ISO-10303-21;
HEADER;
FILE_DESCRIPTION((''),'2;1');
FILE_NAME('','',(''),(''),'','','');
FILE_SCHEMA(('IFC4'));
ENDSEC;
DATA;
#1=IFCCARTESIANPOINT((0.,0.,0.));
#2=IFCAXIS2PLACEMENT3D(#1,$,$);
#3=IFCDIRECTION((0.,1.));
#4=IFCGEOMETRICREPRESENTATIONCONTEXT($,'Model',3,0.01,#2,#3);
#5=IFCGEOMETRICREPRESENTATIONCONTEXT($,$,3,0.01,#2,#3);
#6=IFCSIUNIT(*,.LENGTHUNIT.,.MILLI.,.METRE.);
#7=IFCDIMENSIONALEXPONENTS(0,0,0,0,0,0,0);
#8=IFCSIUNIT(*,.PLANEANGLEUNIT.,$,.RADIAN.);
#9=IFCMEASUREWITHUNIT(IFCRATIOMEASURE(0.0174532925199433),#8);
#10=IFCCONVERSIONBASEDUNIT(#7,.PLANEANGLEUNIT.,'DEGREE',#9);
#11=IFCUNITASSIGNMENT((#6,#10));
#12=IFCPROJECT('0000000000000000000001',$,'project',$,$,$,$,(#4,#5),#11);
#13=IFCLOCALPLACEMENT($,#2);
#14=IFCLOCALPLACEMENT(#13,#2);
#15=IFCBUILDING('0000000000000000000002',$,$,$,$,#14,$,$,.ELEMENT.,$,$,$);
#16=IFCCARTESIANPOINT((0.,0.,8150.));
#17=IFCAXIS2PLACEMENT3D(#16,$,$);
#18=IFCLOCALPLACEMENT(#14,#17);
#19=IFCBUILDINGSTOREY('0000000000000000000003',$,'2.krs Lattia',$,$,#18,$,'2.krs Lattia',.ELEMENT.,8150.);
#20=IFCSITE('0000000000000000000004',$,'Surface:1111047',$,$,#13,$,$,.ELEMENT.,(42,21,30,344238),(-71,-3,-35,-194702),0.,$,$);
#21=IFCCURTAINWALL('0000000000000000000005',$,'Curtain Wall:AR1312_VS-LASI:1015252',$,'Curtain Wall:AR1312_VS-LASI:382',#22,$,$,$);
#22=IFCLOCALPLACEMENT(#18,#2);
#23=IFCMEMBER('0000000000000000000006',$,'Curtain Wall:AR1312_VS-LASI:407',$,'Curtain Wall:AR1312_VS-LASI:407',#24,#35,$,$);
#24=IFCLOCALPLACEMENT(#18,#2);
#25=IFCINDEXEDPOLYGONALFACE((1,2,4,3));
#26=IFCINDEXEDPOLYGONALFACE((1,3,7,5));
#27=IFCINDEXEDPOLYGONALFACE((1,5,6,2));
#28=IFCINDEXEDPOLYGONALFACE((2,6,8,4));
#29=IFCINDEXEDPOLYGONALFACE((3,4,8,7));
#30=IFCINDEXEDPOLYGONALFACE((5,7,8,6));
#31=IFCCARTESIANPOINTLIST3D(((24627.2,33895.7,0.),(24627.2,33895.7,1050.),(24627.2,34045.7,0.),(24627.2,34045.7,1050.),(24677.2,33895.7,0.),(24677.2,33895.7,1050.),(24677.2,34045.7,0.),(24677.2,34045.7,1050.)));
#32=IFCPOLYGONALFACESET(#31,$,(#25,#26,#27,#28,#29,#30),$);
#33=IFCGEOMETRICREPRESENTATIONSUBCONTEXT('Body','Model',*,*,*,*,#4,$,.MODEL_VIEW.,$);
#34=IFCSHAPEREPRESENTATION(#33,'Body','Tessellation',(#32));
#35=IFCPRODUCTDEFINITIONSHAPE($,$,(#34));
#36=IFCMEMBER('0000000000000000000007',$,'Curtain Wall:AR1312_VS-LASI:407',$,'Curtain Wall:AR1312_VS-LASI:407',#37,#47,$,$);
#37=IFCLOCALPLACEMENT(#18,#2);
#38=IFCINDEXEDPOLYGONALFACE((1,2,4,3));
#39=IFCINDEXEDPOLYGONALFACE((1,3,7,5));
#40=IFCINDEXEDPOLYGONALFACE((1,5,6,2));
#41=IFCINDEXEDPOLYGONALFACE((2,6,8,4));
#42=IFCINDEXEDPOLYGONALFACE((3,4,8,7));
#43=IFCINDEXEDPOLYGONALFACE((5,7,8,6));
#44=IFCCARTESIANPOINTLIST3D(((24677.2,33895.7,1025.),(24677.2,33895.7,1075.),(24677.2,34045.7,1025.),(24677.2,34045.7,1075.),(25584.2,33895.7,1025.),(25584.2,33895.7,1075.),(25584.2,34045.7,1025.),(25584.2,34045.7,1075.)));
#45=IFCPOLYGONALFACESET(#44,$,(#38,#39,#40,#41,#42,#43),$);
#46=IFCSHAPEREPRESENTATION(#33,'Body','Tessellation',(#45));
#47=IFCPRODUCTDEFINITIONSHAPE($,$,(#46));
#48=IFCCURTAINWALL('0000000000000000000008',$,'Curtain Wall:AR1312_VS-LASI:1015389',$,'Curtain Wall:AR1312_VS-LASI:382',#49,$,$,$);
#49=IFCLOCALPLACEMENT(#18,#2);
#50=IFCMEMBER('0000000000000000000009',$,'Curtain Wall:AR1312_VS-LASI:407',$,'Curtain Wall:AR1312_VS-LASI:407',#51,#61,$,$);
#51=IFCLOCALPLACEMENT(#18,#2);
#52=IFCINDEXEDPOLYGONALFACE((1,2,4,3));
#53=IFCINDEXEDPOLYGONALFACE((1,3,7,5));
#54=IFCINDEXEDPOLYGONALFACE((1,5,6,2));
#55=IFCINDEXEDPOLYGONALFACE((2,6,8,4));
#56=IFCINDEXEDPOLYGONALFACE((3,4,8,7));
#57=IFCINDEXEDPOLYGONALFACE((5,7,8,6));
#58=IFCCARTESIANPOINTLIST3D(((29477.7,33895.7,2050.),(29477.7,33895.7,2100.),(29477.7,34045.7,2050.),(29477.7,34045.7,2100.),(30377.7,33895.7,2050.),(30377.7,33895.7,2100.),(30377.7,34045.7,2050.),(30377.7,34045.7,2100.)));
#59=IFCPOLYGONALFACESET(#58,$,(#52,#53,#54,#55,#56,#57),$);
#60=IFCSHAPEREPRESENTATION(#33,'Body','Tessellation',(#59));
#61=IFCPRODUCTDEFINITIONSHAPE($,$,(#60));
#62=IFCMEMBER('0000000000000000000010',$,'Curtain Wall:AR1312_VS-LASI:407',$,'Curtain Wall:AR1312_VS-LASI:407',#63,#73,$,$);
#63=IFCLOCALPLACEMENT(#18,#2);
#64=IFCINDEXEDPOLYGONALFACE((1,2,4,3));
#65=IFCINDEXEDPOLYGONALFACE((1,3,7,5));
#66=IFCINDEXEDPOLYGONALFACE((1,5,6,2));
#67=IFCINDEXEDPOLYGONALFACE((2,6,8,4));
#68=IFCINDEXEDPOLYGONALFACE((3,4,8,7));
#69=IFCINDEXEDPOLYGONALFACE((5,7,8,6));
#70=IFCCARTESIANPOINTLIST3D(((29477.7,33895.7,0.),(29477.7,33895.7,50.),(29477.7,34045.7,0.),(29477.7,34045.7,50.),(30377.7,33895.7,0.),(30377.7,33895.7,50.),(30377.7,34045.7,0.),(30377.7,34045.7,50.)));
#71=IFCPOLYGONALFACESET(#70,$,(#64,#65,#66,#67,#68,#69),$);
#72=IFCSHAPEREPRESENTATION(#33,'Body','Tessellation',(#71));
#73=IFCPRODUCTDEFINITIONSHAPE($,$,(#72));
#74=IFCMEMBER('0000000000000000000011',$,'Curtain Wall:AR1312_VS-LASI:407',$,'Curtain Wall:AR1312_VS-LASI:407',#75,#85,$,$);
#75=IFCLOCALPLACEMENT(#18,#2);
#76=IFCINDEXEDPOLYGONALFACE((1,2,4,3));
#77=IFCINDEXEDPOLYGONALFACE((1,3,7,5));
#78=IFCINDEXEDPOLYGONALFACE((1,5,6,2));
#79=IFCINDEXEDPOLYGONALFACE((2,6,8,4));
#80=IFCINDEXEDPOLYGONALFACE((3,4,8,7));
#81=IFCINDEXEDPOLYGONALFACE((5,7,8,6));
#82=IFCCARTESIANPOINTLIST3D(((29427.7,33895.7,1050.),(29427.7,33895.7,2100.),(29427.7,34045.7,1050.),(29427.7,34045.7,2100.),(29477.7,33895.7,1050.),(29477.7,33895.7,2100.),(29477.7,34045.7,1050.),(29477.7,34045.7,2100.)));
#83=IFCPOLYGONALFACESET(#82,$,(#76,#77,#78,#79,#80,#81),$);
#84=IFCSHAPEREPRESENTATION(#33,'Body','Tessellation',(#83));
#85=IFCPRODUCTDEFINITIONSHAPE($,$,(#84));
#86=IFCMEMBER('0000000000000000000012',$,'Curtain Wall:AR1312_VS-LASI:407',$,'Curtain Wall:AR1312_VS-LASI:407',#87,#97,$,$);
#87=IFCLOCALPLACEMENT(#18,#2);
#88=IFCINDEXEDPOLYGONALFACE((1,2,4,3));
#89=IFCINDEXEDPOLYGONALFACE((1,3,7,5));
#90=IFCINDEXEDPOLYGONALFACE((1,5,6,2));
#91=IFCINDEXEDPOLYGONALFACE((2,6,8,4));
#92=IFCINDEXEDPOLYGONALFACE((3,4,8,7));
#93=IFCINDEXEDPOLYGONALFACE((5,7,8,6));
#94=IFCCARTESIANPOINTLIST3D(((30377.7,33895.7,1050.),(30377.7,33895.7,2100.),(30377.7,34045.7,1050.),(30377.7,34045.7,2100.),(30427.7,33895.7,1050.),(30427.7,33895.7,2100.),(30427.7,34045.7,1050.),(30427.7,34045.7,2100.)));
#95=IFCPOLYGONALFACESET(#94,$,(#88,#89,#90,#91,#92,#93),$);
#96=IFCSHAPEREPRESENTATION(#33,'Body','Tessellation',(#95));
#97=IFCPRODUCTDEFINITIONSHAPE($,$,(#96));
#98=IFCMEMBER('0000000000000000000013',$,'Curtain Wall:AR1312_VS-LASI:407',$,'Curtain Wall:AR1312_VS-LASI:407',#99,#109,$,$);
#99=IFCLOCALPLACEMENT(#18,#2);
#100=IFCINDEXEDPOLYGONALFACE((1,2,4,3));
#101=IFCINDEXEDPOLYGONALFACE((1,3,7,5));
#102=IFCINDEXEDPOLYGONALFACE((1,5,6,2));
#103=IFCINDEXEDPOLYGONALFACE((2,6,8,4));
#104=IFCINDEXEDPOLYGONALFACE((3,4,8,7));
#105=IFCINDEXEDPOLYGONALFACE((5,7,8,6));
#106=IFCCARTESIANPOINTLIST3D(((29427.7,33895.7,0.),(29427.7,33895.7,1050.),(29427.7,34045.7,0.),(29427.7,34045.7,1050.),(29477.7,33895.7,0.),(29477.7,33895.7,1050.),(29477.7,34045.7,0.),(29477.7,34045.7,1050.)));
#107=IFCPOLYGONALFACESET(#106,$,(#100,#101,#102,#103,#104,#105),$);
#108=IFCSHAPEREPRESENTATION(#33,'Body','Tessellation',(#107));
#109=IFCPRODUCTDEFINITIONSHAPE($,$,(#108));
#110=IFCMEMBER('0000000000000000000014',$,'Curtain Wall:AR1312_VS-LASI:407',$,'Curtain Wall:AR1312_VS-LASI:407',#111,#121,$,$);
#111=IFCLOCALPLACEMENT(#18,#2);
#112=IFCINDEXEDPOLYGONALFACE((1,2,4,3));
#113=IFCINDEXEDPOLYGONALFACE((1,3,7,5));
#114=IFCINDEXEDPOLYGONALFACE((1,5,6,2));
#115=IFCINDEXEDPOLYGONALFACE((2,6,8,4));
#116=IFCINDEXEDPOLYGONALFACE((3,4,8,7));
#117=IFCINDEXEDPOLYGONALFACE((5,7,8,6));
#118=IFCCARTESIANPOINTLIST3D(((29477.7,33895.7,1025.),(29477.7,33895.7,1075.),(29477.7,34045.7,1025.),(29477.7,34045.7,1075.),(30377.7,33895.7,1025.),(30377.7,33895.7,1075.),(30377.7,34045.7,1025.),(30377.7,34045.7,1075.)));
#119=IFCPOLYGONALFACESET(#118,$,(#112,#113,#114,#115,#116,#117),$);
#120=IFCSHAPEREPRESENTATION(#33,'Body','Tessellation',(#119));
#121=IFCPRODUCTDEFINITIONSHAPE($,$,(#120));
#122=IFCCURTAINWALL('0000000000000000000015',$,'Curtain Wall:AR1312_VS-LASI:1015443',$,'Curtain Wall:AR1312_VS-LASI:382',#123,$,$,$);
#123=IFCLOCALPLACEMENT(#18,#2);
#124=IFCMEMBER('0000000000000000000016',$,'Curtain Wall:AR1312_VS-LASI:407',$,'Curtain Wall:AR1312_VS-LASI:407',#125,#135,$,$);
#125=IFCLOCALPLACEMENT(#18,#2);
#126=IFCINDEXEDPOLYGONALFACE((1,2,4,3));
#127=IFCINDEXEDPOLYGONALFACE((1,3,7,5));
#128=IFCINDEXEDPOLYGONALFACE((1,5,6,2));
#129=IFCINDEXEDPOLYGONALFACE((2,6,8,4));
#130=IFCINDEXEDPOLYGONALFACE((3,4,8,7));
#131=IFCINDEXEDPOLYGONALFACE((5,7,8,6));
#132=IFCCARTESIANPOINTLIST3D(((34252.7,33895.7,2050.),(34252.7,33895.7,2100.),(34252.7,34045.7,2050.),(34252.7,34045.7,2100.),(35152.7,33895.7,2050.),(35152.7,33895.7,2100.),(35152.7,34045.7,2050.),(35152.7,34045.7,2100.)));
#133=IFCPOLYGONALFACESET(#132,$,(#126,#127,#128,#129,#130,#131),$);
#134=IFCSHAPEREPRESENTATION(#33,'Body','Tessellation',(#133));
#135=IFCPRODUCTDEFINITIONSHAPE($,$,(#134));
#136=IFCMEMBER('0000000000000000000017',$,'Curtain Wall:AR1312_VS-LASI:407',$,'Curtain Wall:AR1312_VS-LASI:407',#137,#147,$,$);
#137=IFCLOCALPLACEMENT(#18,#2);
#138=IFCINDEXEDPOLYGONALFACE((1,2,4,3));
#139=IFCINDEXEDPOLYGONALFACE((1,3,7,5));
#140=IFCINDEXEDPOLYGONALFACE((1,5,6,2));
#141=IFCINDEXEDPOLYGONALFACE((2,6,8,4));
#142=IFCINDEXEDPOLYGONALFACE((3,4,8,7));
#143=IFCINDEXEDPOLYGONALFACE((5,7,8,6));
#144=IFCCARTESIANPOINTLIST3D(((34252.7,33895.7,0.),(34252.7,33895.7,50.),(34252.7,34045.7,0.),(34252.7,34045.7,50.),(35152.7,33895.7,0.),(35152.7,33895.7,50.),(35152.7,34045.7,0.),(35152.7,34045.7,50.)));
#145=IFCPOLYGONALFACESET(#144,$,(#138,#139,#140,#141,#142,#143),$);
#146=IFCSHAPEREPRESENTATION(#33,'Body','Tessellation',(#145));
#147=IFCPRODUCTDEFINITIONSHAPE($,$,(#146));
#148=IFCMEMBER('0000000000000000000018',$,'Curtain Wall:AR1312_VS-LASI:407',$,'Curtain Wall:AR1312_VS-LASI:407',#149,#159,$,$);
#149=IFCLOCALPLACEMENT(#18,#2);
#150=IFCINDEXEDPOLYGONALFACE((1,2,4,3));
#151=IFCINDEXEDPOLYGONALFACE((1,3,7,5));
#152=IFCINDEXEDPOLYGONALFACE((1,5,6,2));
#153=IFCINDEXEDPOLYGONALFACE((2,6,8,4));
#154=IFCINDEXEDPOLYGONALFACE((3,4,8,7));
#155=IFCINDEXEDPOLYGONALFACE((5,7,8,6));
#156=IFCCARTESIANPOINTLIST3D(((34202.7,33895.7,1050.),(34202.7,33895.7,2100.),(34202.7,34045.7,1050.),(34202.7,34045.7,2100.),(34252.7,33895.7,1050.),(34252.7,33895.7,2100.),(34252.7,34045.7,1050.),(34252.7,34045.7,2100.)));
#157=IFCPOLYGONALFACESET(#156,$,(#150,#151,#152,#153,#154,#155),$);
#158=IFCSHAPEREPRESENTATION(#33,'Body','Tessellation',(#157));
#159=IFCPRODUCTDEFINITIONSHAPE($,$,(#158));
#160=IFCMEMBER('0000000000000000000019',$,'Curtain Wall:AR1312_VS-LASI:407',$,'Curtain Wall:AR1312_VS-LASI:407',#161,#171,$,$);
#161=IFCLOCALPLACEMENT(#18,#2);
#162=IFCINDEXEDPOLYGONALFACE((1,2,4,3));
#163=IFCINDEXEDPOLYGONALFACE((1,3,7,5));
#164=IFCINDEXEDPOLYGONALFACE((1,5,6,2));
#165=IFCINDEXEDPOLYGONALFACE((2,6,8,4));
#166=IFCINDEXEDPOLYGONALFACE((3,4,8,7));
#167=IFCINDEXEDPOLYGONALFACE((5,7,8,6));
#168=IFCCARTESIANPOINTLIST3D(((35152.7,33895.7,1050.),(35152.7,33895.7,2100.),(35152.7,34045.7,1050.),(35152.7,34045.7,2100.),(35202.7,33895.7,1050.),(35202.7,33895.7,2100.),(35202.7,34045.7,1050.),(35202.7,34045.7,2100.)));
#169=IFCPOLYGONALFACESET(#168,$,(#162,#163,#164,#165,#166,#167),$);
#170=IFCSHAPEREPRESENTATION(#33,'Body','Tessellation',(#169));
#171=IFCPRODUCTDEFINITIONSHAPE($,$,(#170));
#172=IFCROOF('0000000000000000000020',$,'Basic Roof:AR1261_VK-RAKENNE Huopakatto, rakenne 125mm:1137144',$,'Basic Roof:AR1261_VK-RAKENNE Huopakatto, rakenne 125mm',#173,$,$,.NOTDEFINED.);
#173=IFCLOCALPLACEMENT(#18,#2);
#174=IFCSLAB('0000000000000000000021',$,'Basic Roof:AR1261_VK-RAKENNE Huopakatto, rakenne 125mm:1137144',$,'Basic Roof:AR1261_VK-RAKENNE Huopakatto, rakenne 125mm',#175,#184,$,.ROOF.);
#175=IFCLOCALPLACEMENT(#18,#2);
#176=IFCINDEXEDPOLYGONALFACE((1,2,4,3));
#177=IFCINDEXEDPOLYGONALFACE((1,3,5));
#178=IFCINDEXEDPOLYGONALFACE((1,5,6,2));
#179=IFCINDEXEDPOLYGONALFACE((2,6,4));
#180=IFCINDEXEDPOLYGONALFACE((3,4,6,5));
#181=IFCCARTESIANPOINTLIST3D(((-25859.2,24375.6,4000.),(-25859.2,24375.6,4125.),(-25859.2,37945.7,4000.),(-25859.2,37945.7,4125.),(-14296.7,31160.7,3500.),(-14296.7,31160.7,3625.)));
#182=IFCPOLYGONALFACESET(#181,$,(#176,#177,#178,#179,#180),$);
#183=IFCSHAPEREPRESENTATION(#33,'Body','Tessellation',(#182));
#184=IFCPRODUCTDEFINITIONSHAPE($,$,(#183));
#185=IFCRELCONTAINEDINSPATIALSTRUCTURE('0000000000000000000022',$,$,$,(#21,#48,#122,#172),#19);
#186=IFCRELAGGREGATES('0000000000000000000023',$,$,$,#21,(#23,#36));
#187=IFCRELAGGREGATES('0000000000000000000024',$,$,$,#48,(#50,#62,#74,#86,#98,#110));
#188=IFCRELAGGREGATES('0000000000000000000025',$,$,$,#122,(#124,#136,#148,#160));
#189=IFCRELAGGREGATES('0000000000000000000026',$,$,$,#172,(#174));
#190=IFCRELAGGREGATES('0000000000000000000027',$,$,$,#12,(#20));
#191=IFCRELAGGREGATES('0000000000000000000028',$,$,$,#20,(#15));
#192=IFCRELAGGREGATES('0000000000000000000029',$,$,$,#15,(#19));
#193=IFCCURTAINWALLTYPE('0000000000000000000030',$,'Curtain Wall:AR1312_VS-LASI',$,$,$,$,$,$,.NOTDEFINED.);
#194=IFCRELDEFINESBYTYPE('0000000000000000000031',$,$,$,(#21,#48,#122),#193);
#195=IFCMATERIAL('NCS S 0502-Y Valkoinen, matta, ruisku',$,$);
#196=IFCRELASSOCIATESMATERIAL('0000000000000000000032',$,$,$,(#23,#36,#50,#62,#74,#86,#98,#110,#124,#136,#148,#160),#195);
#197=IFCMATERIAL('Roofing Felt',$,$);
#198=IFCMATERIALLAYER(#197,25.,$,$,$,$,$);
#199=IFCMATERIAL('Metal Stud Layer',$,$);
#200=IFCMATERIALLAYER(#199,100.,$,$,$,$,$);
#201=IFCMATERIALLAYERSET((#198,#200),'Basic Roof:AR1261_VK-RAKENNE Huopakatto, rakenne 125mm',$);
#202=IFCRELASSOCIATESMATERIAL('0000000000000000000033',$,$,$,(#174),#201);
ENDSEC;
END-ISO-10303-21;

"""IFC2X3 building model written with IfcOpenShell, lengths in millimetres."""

from ifc_helpers import new_model, entity, si_unit, converted_unit, direction, frame, frame_2d, origin, place, context, subcontext, project, spatial, polyline, rectangle, outline, extrude, material, layer, layer_set, type_object, element, aggregate, save


model = new_model("IFC2X3")

# Units and contexts
model_context = context("Model", 3, precision=0.01, world=origin(), true_north=direction((0.0, 1.0)))
context_of_model = context(None, 3, precision=0.01, world=origin(), true_north=direction((0.0, 1.0)))
body_context = subcontext(model_context, "Body", "Model", "MODEL_VIEW")
ifc_project = project(units=[si_unit("LENGTHUNIT", "METRE", prefix="MILLI"), converted_unit("PLANEANGLEUNIT", "DEGREE", entity("IfcRatioMeasure", 0.0174532925199433), si_unit("PLANEANGLEUNIT", "RADIAN"), dimensions=[0, 0, 0, 0, 0, 0, 0])], contexts=[model_context, context_of_model])

# Site, building, storey
site_placement = place(None, origin())
site = spatial("IfcSite", under=ifc_project, at=site_placement, Name="Surface:1111047", CompositionType="ELEMENT", RefLatitude=(42, 21, 30, 344238), RefLongitude=(-71, -3, -35, -194702), RefElevation=0.0)
building_placement = place(site_placement, origin())
building = spatial("IfcBuilding", under=site, at=building_placement, CompositionType="ELEMENT")
storey_placement = place(building_placement, frame((0.0, 0.0, 8150.0)))
storey = spatial("IfcBuildingStorey", under=building, at=storey_placement, Name="2.krs Lattia", LongName="2.krs Lattia", CompositionType="ELEMENT", Elevation=8150.0)

# Curtain walls, members
curtain_wall_type = type_object("IfcCurtainWallType", Name="Curtain Wall:AR1312_VS-LASI", PredefinedType="NOTDEFINED")
curtain_wall_1_placement = place(storey_placement, frame((0.0, 0.0, -8150.0)))
curtain_wall_1 = element("IfcCurtainWall", 1, at=curtain_wall_1_placement, inside=storey, type_object=curtain_wall_type, Name="Curtain Wall:AR1312_VS-LASI:1015252", ObjectType="Curtain Wall:AR1312_VS-LASI:382")
ifc_material_1 = material(Name="NCS S 0502-Y Valkoinen, matta, ruisku")
member_1_placement = place(curtain_wall_1_placement, frame((0.0, 0.0, 8150.0)))
member_1 = element("IfcMember", 2, at=member_1_placement, material=ifc_material_1, Name="Curtain Wall:AR1312_VS-LASI:407", ObjectType="Curtain Wall:AR1312_VS-LASI:407", context=body_context, shape_type="SweptSolid", body=[
    extrude(rectangle(XDim=50.0, YDim=150.0, at=frame_2d((0.0, 0.0), x_axis=(1.0, 0.0))), frame((24652.2, 33970.7, 1050.0), z_axis=(0.0, 0.0, -1.0), x_axis=(-1.0, 0.0, 0.0)), (0.0, 0.0, 1.0), 1050.0),
])
member_2_placement = place(curtain_wall_1_placement, frame((0.0, 0.0, 8150.0)))
member_2 = element("IfcMember", 3, at=member_2_placement, material=ifc_material_1, Name="Curtain Wall:AR1312_VS-LASI:407", ObjectType="Curtain Wall:AR1312_VS-LASI:407", context=body_context, shape_type="SweptSolid", body=[
    extrude(rectangle(XDim=50.0, YDim=150.0, at=frame_2d((0.0, 0.0), x_axis=(1.0, 0.0))), frame((25584.2, 33970.7, 1050.0), z_axis=(-1.0, 0.0, 0.0), x_axis=(0.0, 0.0, -1.0)), (0.0, 0.0, 1.0), 907.1),
])
aggregate(curtain_wall_1, [member_1, member_2])
curtain_wall_2_placement = place(storey_placement, frame((0.0, 0.0, -8150.0)))
curtain_wall_2 = element("IfcCurtainWall", 4, at=curtain_wall_2_placement, inside=storey, type_object=curtain_wall_type, Name="Curtain Wall:AR1312_VS-LASI:1015389", ObjectType="Curtain Wall:AR1312_VS-LASI:382")
member_3_placement = place(curtain_wall_2_placement, frame((0.0, 0.0, 8150.0)))
member_3 = element("IfcMember", 5, at=member_3_placement, material=ifc_material_1, Name="Curtain Wall:AR1312_VS-LASI:407", ObjectType="Curtain Wall:AR1312_VS-LASI:407", context=body_context, shape_type="SweptSolid", body=[
    extrude(rectangle(XDim=50.0, YDim=150.0, at=frame_2d((0.0, 0.0), x_axis=(1.0, 0.0))), frame((30377.7, 33970.7, 2075.0), z_axis=(-1.0, 0.0, 0.0), x_axis=(0.0, 0.0, -1.0)), (0.0, 0.0, 1.0), 900.0),
])
member_4_placement = place(curtain_wall_2_placement, frame((0.0, 0.0, 8150.0)))
member_4 = element("IfcMember", 6, at=member_4_placement, material=ifc_material_1, Name="Curtain Wall:AR1312_VS-LASI:407", ObjectType="Curtain Wall:AR1312_VS-LASI:407", context=body_context, shape_type="SweptSolid", body=[
    extrude(rectangle(XDim=50.0, YDim=150.0, at=frame_2d((0.0, 0.0), x_axis=(1.0, 0.0))), frame((29477.7, 33970.7, 25.0), z_axis=(1.0, 0.0, 0.0), x_axis=(0.0, 0.0, -1.0)), (0.0, 0.0, 1.0), 900.0),
])
member_5_placement = place(curtain_wall_2_placement, frame((0.0, 0.0, 8150.0)))
member_5 = element("IfcMember", 7, at=member_5_placement, material=ifc_material_1, Name="Curtain Wall:AR1312_VS-LASI:407", ObjectType="Curtain Wall:AR1312_VS-LASI:407", context=body_context, shape_type="SweptSolid", body=[
    extrude(rectangle(XDim=50.0, YDim=150.0, at=frame_2d((0.0, 0.0), x_axis=(1.0, 0.0))), frame((29452.7, 33970.7, 2100.0), z_axis=(0.0, 0.0, -1.0), x_axis=(-1.0, 0.0, 0.0)), (0.0, 0.0, 1.0), 1050.0),
])
member_6_placement = place(curtain_wall_2_placement, frame((0.0, 0.0, 8150.0)))
member_6 = element("IfcMember", 8, at=member_6_placement, material=ifc_material_1, Name="Curtain Wall:AR1312_VS-LASI:407", ObjectType="Curtain Wall:AR1312_VS-LASI:407", context=body_context, shape_type="SweptSolid", body=[
    extrude(rectangle(XDim=50.0, YDim=150.0, at=frame_2d((0.0, 0.0), x_axis=(1.0, 0.0))), frame((30402.7, 33970.7, 1050.0), z_axis=(0.0, 0.0, 1.0), x_axis=(-1.0, 0.0, 0.0)), (0.0, 0.0, 1.0), 1050.0),
])
member_7_placement = place(curtain_wall_2_placement, frame((0.0, 0.0, 8150.0)))
member_7 = element("IfcMember", 9, at=member_7_placement, material=ifc_material_1, Name="Curtain Wall:AR1312_VS-LASI:407", ObjectType="Curtain Wall:AR1312_VS-LASI:407", context=body_context, shape_type="SweptSolid", body=[
    extrude(rectangle(XDim=50.0, YDim=150.0, at=frame_2d((0.0, 0.0), x_axis=(1.0, 0.0))), frame((29452.7, 33970.7, 1050.0), z_axis=(0.0, 0.0, -1.0), x_axis=(-1.0, 0.0, 0.0)), (0.0, 0.0, 1.0), 1050.0),
])
member_8_placement = place(curtain_wall_2_placement, frame((0.0, 0.0, 8150.0)))
member_8 = element("IfcMember", 10, at=member_8_placement, material=ifc_material_1, Name="Curtain Wall:AR1312_VS-LASI:407", ObjectType="Curtain Wall:AR1312_VS-LASI:407", context=body_context, shape_type="SweptSolid", body=[
    extrude(rectangle(XDim=50.0, YDim=150.0, at=frame_2d((0.0, 0.0), x_axis=(1.0, 0.0))), frame((30377.7, 33970.7, 1050.0), z_axis=(-1.0, 0.0, 0.0), x_axis=(0.0, 0.0, -1.0)), (0.0, 0.0, 1.0), 900.0),
])
aggregate(curtain_wall_2, [member_3, member_4, member_5, member_6, member_7, member_8])
curtain_wall_3_placement = place(storey_placement, frame((0.0, 0.0, -8150.0)))
curtain_wall_3 = element("IfcCurtainWall", 11, at=curtain_wall_3_placement, inside=storey, type_object=curtain_wall_type, Name="Curtain Wall:AR1312_VS-LASI:1015443", ObjectType="Curtain Wall:AR1312_VS-LASI:382")
member_9_placement = place(curtain_wall_3_placement, frame((0.0, 0.0, 8150.0)))
member_9 = element("IfcMember", 12, at=member_9_placement, material=ifc_material_1, Name="Curtain Wall:AR1312_VS-LASI:407", ObjectType="Curtain Wall:AR1312_VS-LASI:407", context=body_context, shape_type="SweptSolid", body=[
    extrude(rectangle(XDim=50.0, YDim=150.0, at=frame_2d((0.0, 0.0), x_axis=(1.0, 0.0))), frame((35152.7, 33970.7, 2075.0), z_axis=(-1.0, 0.0, 0.0), x_axis=(0.0, 0.0, -1.0)), (0.0, 0.0, 1.0), 900.0),
])
member_10_placement = place(curtain_wall_3_placement, frame((0.0, 0.0, 8150.0)))
member_10 = element("IfcMember", 13, at=member_10_placement, material=ifc_material_1, Name="Curtain Wall:AR1312_VS-LASI:407", ObjectType="Curtain Wall:AR1312_VS-LASI:407", context=body_context, shape_type="SweptSolid", body=[
    extrude(rectangle(XDim=50.0, YDim=150.0, at=frame_2d((0.0, 0.0), x_axis=(1.0, 0.0))), frame((34252.7, 33970.7, 25.0), z_axis=(1.0, 0.0, 0.0), x_axis=(0.0, 0.0, -1.0)), (0.0, 0.0, 1.0), 900.0),
])
member_11_placement = place(curtain_wall_3_placement, frame((0.0, 0.0, 8150.0)))
member_11 = element("IfcMember", 14, at=member_11_placement, material=ifc_material_1, Name="Curtain Wall:AR1312_VS-LASI:407", ObjectType="Curtain Wall:AR1312_VS-LASI:407", context=body_context, shape_type="SweptSolid", body=[
    extrude(rectangle(XDim=50.0, YDim=150.0, at=frame_2d((0.0, 0.0), x_axis=(1.0, 0.0))), frame((34227.7, 33970.7, 2100.0), z_axis=(0.0, 0.0, -1.0), x_axis=(-1.0, 0.0, 0.0)), (0.0, 0.0, 1.0), 1050.0),
])
member_12_placement = place(curtain_wall_3_placement, frame((0.0, 0.0, 8150.0)))
member_12 = element("IfcMember", 15, at=member_12_placement, material=ifc_material_1, Name="Curtain Wall:AR1312_VS-LASI:407", ObjectType="Curtain Wall:AR1312_VS-LASI:407", context=body_context, shape_type="SweptSolid", body=[
    extrude(rectangle(XDim=50.0, YDim=150.0, at=frame_2d((0.0, 0.0), x_axis=(1.0, 0.0))), frame((35177.7, 33970.7, 1050.0), z_axis=(0.0, 0.0, 1.0), x_axis=(-1.0, 0.0, 0.0)), (0.0, 0.0, 1.0), 1050.0),
])
aggregate(curtain_wall_3, [member_9, member_10, member_11, member_12])

# Shared definitions
ifc_material_2 = material(Name="Roofing Felt")
ifc_layer_1 = layer(ifc_material_2, 25.0)
ifc_material_3 = material(Name="Metal Stud Layer")
ifc_layer_2 = layer(ifc_material_3, 100.0)
ifc_layer_set = layer_set([ifc_layer_1, ifc_layer_2], Name="Basic Roof:AR1261_VK-RAKENNE Huopakatto, rakenne 125mm")

# Roof, slab
roof_1_placement = place(storey_placement, frame((-25859.2, 24375.6, 3500.0)))
roof_1 = element("IfcRoof", 16, at=roof_1_placement, inside=storey, Name="Basic Roof:AR1261_VK-RAKENNE Huopakatto, rakenne 125mm:1137144", ObjectType="Basic Roof:AR1261_VK-RAKENNE Huopakatto, rakenne 125mm", ShapeType="NOTDEFINED")
slab_1_placement = place(roof_1_placement, origin())
slab_1 = element("IfcSlab", 17, at=slab_1_placement, material=ifc_layer_set, Name="Basic Roof:AR1261_VK-RAKENNE Huopakatto, rakenne 125mm:1137144", ObjectType="Basic Roof:AR1261_VK-RAKENNE Huopakatto, rakenne 125mm", PredefinedType="ROOF", context=body_context, shape_type="SweptSolid", body=[
    extrude(outline(polyline([(-5786.7, 6785.1), (-5786.7, -6785.1), (5786.7, 0.0), (-5786.7, 6785.1)])), frame((5781.2, 6785.1, 250.0), z_axis=(0.043203, 0.0, 0.999066), x_axis=(0.999066, 0.0, -0.043203)), (-0.043203, 0.0, 0.999066), 125.0),
])
aggregate(roof_1, [slab_1])

save(model, "model.ifc")
